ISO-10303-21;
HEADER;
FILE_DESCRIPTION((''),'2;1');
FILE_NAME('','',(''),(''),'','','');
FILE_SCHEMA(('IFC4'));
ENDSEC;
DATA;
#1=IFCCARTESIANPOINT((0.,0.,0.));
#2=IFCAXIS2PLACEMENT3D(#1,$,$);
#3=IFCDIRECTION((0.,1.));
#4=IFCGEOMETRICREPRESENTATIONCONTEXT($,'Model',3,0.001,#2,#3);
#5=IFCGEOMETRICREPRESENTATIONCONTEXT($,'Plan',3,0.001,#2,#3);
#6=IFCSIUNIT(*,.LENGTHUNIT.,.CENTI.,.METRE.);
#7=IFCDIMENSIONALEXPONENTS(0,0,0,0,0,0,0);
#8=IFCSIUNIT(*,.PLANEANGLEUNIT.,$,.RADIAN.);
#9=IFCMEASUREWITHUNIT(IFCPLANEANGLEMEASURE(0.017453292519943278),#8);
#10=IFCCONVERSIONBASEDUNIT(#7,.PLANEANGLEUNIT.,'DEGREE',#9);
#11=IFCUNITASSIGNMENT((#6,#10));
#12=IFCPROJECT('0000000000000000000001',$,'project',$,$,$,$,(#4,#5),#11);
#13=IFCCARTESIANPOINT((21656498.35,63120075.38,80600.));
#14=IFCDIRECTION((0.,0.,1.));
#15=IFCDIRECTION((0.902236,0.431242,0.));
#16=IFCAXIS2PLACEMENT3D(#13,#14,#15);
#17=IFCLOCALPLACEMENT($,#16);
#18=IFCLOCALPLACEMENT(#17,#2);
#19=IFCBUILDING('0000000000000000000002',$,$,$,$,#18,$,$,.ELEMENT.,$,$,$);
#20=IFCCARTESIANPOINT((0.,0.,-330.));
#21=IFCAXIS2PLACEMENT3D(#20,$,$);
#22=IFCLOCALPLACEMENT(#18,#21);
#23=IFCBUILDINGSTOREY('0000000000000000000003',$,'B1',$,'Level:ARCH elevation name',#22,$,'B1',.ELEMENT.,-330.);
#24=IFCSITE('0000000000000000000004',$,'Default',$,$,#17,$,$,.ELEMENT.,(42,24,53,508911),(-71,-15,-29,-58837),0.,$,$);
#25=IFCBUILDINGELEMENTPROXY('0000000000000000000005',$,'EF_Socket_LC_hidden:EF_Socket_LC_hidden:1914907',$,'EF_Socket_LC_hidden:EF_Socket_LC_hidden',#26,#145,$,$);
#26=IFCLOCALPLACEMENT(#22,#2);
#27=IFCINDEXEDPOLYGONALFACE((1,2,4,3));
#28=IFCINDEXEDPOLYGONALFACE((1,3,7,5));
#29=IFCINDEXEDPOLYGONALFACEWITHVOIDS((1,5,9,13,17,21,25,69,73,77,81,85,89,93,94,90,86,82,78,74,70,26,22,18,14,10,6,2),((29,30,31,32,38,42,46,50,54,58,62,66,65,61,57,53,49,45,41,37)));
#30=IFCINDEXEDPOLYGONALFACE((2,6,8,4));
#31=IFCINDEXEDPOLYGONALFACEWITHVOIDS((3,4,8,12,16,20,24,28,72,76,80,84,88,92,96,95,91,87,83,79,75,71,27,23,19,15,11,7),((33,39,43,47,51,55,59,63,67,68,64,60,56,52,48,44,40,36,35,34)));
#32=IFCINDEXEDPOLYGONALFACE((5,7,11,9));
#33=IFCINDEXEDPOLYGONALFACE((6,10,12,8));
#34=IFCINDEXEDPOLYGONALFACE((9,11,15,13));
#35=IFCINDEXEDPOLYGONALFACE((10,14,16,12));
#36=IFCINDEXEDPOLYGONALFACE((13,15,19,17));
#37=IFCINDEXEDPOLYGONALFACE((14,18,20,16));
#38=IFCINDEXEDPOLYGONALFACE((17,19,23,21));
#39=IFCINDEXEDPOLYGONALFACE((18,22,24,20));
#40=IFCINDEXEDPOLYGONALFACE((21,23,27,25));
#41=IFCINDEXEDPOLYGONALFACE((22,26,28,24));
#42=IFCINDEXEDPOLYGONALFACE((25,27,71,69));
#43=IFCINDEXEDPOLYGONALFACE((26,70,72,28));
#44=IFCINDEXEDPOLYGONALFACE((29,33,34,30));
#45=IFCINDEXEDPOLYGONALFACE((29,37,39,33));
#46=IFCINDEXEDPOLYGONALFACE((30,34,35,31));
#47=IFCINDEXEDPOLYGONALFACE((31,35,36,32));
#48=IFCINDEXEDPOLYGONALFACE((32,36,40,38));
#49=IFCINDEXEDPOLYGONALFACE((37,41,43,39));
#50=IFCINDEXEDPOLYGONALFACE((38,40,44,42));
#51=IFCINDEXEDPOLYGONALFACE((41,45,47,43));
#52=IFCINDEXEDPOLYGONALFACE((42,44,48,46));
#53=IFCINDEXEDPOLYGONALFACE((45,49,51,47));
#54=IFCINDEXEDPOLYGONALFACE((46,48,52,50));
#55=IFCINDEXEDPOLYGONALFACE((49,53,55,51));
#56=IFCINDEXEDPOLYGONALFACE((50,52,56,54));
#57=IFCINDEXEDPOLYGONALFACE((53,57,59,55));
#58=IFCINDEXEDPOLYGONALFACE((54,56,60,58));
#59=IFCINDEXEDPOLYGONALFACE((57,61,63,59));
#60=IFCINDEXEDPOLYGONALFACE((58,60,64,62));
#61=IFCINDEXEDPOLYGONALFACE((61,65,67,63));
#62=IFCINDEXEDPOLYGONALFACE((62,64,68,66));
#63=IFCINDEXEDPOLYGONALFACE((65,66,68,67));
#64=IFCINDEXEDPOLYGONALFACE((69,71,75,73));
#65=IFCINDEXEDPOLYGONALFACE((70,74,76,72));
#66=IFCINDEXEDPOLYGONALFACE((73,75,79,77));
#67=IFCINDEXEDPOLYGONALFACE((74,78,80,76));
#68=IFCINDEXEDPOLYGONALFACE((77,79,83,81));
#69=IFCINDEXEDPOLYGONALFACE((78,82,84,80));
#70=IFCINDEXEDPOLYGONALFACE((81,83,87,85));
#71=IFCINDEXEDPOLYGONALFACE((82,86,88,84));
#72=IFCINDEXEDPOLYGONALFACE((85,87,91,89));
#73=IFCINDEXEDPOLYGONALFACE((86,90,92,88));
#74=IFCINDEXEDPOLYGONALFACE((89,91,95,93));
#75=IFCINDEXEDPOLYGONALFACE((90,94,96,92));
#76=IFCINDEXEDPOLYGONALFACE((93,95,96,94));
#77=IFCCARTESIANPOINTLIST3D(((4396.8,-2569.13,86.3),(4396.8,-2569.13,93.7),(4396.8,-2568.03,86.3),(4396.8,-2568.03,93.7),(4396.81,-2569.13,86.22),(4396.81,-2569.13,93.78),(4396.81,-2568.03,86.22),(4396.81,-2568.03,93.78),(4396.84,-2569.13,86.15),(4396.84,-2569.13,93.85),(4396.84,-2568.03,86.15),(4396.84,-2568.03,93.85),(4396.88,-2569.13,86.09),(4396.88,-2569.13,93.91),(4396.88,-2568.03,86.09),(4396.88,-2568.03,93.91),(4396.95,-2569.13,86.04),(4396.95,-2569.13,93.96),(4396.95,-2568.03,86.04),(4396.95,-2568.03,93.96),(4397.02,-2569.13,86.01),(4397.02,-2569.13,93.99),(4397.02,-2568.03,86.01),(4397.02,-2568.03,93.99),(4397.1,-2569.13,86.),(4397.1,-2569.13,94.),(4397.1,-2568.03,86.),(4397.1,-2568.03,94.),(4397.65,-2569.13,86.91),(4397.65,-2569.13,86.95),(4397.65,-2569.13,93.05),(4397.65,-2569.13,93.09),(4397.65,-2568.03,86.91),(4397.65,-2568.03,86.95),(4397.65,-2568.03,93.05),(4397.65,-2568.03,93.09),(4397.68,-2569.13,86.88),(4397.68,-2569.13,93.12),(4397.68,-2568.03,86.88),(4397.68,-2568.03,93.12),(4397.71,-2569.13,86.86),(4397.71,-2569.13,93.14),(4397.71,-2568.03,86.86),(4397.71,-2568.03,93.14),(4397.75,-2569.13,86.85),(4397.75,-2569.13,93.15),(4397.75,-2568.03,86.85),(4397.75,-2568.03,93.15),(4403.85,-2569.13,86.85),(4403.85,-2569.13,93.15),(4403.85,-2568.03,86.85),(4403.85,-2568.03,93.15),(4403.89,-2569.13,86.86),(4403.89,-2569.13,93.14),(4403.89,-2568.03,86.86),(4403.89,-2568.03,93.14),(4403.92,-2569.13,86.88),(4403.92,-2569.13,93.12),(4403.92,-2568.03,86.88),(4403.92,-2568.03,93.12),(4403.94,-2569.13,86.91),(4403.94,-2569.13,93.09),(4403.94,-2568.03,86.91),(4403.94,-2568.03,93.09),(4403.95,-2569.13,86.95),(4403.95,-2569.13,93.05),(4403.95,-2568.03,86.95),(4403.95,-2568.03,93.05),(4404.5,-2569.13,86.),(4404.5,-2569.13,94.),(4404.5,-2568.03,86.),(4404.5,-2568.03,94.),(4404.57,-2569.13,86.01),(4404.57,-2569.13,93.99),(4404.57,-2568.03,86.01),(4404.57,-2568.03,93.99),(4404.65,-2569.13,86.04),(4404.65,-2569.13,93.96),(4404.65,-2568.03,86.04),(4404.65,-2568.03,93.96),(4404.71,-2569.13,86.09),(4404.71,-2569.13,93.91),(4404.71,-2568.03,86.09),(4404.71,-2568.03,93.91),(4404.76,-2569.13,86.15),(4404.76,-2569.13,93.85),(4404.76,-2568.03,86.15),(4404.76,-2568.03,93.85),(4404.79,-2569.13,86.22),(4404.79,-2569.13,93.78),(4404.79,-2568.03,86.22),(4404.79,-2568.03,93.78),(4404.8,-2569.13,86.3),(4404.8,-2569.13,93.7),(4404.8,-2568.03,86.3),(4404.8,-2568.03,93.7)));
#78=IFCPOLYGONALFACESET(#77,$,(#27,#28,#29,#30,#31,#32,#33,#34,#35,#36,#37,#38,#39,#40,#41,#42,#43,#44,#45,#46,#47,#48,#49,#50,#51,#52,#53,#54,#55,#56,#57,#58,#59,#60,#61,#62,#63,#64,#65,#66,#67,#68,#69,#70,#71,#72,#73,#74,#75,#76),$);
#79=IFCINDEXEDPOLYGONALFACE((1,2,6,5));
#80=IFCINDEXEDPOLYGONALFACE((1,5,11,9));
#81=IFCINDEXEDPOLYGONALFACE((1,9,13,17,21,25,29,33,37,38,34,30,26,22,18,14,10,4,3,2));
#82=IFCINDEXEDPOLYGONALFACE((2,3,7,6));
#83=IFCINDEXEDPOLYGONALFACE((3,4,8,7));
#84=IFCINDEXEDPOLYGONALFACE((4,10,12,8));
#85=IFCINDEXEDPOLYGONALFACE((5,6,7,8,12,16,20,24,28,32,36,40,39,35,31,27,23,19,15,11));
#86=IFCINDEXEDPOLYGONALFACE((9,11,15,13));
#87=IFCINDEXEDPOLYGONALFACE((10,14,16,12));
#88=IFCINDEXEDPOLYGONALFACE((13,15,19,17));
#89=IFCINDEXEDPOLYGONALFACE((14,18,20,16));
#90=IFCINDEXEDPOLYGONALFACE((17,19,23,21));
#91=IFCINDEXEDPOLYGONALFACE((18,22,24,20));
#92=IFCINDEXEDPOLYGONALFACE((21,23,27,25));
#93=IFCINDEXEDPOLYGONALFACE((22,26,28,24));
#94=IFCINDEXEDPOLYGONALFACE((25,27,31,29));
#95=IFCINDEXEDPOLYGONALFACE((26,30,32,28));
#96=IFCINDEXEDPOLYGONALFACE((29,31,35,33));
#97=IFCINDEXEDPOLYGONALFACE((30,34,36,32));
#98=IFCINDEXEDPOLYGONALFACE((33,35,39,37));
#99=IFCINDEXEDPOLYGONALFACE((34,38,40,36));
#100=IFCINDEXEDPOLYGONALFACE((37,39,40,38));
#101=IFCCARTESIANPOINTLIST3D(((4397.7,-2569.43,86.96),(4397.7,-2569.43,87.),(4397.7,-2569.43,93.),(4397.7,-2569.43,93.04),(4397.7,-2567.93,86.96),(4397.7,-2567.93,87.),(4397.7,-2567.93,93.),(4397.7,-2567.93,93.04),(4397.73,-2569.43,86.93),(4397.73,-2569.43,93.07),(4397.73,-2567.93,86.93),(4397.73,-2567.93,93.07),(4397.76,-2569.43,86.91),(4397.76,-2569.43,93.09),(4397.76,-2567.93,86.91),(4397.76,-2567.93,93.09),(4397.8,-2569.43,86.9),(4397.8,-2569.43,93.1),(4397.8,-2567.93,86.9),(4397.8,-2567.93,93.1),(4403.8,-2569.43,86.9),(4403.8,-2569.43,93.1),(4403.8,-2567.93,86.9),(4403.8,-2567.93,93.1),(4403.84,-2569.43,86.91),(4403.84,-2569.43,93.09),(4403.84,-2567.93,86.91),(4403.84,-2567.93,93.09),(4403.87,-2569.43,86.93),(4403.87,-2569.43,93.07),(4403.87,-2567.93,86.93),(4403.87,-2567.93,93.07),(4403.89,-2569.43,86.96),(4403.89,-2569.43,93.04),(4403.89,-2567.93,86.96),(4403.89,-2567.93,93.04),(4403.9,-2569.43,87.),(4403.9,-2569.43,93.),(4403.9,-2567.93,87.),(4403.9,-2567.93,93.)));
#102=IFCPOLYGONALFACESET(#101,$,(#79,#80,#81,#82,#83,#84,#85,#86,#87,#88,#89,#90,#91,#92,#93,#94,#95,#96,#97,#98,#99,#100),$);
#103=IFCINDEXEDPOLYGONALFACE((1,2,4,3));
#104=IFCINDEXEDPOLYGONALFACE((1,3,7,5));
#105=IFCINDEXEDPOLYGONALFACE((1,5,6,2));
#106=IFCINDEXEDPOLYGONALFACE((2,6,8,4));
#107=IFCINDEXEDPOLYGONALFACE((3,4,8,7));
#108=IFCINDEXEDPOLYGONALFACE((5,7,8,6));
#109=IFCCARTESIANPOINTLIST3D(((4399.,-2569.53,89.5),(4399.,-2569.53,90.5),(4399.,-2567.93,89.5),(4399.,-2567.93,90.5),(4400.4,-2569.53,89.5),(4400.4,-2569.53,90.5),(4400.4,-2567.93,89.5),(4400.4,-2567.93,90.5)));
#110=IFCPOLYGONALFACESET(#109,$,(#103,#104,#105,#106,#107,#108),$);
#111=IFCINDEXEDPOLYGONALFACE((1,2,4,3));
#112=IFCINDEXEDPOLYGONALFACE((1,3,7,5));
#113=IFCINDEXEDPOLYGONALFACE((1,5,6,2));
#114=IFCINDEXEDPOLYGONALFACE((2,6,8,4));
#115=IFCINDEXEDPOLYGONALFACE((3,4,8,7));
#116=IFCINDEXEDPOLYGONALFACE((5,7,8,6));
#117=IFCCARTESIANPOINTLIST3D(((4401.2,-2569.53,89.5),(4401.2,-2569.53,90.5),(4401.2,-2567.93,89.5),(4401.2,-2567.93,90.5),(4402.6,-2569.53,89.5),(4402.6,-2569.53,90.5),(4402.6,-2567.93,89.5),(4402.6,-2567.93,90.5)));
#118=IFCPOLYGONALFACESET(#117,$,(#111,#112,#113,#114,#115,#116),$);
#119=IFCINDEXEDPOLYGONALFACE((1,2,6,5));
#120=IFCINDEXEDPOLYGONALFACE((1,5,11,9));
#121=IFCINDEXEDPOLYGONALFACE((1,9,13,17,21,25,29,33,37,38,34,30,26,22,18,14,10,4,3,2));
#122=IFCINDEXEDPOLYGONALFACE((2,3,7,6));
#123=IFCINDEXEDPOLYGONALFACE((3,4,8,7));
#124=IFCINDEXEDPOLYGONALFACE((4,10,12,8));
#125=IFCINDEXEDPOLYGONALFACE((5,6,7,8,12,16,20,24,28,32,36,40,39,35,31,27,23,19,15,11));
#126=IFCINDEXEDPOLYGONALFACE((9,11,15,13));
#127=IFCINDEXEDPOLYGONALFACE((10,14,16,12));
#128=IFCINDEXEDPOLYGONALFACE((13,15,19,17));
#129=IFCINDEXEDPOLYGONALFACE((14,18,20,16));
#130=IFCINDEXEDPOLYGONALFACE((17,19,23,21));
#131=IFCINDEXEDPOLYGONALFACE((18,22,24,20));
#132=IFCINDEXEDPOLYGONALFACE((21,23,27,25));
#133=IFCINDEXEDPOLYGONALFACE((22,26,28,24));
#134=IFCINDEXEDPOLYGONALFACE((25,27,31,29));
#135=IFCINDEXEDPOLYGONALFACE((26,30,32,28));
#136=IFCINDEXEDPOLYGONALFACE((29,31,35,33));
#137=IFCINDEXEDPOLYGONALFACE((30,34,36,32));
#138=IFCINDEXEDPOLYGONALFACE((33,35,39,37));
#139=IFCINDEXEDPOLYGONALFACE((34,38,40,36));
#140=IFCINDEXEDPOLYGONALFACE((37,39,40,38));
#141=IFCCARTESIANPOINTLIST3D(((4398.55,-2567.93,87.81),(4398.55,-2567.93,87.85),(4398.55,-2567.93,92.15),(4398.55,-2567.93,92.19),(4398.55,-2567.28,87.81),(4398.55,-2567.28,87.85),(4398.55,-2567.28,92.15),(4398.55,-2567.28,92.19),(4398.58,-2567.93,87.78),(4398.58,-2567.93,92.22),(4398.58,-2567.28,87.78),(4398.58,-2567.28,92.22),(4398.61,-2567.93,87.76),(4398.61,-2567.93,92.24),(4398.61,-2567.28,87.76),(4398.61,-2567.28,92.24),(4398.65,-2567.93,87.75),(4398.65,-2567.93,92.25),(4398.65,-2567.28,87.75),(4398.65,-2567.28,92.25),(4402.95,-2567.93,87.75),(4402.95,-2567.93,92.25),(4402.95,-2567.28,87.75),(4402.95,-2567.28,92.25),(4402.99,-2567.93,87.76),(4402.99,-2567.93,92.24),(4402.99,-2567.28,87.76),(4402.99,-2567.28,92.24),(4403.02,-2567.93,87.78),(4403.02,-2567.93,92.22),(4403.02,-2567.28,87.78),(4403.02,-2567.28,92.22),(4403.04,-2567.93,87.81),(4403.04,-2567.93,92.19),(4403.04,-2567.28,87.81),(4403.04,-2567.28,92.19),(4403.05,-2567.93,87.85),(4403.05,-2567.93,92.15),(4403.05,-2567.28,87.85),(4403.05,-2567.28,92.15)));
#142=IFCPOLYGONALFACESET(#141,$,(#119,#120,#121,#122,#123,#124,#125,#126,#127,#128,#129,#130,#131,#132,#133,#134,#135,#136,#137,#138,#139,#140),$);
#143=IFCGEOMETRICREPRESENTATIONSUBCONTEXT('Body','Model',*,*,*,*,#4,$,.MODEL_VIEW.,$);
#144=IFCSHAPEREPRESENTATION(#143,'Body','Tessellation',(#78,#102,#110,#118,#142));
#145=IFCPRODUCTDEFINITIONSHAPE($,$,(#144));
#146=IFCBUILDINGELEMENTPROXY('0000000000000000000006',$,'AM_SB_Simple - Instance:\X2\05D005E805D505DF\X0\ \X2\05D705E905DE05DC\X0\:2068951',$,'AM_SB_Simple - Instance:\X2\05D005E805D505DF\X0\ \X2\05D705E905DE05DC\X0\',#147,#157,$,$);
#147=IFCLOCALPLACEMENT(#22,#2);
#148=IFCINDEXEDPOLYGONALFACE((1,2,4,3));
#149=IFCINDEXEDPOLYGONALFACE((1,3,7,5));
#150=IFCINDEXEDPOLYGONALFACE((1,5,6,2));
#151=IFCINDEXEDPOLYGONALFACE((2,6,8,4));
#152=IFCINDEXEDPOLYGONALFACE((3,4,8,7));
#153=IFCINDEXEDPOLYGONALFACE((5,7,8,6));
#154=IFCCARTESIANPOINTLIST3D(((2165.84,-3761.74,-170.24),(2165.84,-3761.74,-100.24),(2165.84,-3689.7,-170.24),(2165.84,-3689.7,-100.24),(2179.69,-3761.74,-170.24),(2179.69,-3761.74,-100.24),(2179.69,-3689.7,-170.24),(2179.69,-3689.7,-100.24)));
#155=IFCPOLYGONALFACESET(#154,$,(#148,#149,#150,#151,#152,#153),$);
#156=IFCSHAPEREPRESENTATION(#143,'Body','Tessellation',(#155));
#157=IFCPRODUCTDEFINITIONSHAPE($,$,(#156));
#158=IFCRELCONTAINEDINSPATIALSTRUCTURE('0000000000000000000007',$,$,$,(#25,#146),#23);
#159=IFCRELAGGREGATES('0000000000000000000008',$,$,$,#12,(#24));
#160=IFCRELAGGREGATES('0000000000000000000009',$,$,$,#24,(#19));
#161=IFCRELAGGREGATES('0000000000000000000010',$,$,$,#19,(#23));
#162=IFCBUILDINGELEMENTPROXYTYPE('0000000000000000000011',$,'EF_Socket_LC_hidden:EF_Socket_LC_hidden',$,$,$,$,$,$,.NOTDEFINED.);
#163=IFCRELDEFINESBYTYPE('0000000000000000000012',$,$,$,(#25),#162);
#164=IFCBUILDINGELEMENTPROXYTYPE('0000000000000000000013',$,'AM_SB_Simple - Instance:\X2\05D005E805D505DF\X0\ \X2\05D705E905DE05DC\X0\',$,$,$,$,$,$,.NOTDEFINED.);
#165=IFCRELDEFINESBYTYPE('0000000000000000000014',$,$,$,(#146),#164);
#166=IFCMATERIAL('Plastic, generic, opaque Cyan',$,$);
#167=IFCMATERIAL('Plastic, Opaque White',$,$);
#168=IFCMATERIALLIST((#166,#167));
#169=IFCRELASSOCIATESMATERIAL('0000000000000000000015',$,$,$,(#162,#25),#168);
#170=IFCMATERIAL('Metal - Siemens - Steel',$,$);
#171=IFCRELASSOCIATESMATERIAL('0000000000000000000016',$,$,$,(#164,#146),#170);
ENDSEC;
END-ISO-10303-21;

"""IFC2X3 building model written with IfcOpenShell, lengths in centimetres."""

from ifc_helpers import new_model, entity, si_unit, converted_unit, direction, frame, frame_2d, origin, origin_2d_with_axis, place, context, subcontext, project, spatial, polyline, circle_curve, parameter, trimmed, segment, composite_curve, rectangle, outline, extrude, source, transform, mapped, material, material_list, type_object, type_shapes, element, save


model = new_model("IFC2X3")

# Units and contexts
model_context = context("Model", 3, precision=0.001, world=origin(), true_north=direction((0.0, 1.0)))
plan_context = context("Plan", 3, precision=0.001, world=origin(), true_north=direction((0.0, 1.0)))
body_context = subcontext(model_context, "Body", "Model", "MODEL_VIEW")
ifc_project = project(units=[si_unit("LENGTHUNIT", "METRE", prefix="CENTI"), converted_unit("PLANEANGLEUNIT", "DEGREE", entity("IfcPlaneAngleMeasure", 0.017453292519943278), si_unit("PLANEANGLEUNIT", "RADIAN"), dimensions=[0, 0, 0, 0, 0, 0, 0])], contexts=[model_context, plan_context])

# Site, building, storey
site_placement = place(None, frame((21656498.35, 63120075.38, 80600.0), z_axis=(0.0, 0.0, 1.0), x_axis=(0.902236, 0.431242, 0.0)))
site = spatial("IfcSite", under=ifc_project, at=site_placement, Name="Default", CompositionType="ELEMENT", RefLatitude=(42, 24, 53, 508911), RefLongitude=(-71, -15, -29, -58837), RefElevation=0.0)
building_placement = place(site_placement, origin())
building = spatial("IfcBuilding", under=site, at=building_placement, CompositionType="ELEMENT")
storey_placement = place(building_placement, frame((0.0, 0.0, -330.0)))
storey = spatial("IfcBuildingStorey", under=building, at=storey_placement, Name="B1", ObjectType="Level:ARCH elevation name", LongName="B1", CompositionType="ELEMENT", Elevation=-330.0)

# Building element proxies
ifc_material_1 = material(Name="Plastic, generic, opaque Cyan")
ifc_material_2 = material(Name="Plastic, Opaque White")
ifc_material_list_1 = material_list([ifc_material_1, ifc_material_2])
building_element_proxy_type_1 = type_object("IfcBuildingElementProxyType", Name="EF_Socket_LC_hidden:EF_Socket_LC_hidden", PredefinedType="NOTDEFINED", material=ifc_material_list_1)
shared_shape_1 = source(origin(), body_context, "Body", "SweptSolid", [
    extrude(outline(composite_curve([segment(trimmed(circle_curve(frame_2d((3.7, -3.7), x_axis=(1.0, 0.0)), 0.3), [parameter(270.0)], [parameter(0.0)], True, "PARAMETER"), True, "CONTINUOUS"), segment(polyline([(4.0, -3.7), (4.0, 3.7)]), True, "CONTINUOUS"), segment(trimmed(circle_curve(frame_2d((3.7, 3.7), x_axis=(1.0, 0.0)), 0.3), [parameter(0.0)], [parameter(90.0)], True, "PARAMETER"), True, "CONTINUOUS"), segment(polyline([(3.7, 4.0), (-3.7, 4.0)]), True, "CONTINUOUS"), segment(trimmed(circle_curve(frame_2d((-3.7, 3.7), x_axis=(1.0, 0.0)), 0.3), [parameter(90.0)], [parameter(180.0)], True, "PARAMETER"), True, "CONTINUOUS"), segment(polyline([(-4.0, 3.7), (-4.0, -3.7)]), True, "CONTINUOUS"), segment(trimmed(circle_curve(frame_2d((-3.7, -3.7), x_axis=(1.0, 0.0)), 0.3), [parameter(180.0)], [parameter(270.0)], True, "PARAMETER"), True, "CONTINUOUS"), segment(polyline([(-3.7, -4.0), (3.7, -4.0)]), True, "CONTINUOUS")], self_intersect=False), holes=[composite_curve([segment(polyline([(-3.15, -3.05), (-3.15, 3.05)]), True, "CONTINUOUS"), segment(trimmed(circle_curve(frame_2d((-3.05, 3.05), x_axis=(1.0, 0.0)), 0.1), [parameter(90.0)], [parameter(180.0)], True, "PARAMETER"), False, "CONTINUOUS"), segment(polyline([(-3.05, 3.15), (3.05, 3.15)]), True, "CONTINUOUS"), segment(trimmed(circle_curve(frame_2d((3.05, 3.05), x_axis=(1.0, 0.0)), 0.1), [parameter(360.0)], [parameter(90.0)], True, "PARAMETER"), False, "CONTINUOUS"), segment(polyline([(3.15, 3.05), (3.15, -3.05)]), True, "CONTINUOUS"), segment(trimmed(circle_curve(frame_2d((3.05, -3.05), x_axis=(1.0, 0.0)), 0.1), [parameter(270.0)], [parameter(360.0)], True, "PARAMETER"), False, "CONTINUOUS"), segment(polyline([(3.05, -3.15), (-3.05, -3.15)]), True, "CONTINUOUS"), segment(trimmed(circle_curve(frame_2d((-3.05, -3.05), x_axis=(1.0, 0.0)), 0.1), [parameter(180.0)], [parameter(270.0)], True, "PARAMETER"), False, "CONTINUOUS")], self_intersect=False)]), frame((0.0, 0.0, 0.0), z_axis=(0.0, 1.0, 0.0), x_axis=(1.0, 0.0, 0.0)), (0.0, 0.0, 1.0), 1.1),
    extrude(outline(composite_curve([segment(trimmed(circle_curve(frame_2d((3.0, -3.0), x_axis=(1.0, 0.0)), 0.1), [parameter(270.0)], [parameter(0.0)], True, "PARAMETER"), True, "CONTINUOUS"), segment(polyline([(3.1, -3.0), (3.1, 3.0)]), True, "CONTINUOUS"), segment(trimmed(circle_curve(frame_2d((3.0, 3.0), x_axis=(1.0, 0.0)), 0.1), [parameter(0.0)], [parameter(90.0)], True, "PARAMETER"), True, "CONTINUOUS"), segment(polyline([(3.0, 3.1), (-3.0, 3.1)]), True, "CONTINUOUS"), segment(trimmed(circle_curve(frame_2d((-3.0, 3.0), x_axis=(1.0, 0.0)), 0.1), [parameter(90.0)], [parameter(180.0)], True, "PARAMETER"), True, "CONTINUOUS"), segment(polyline([(-3.1, 3.0), (-3.1, -3.0)]), True, "CONTINUOUS"), segment(trimmed(circle_curve(frame_2d((-3.0, -3.0), x_axis=(1.0, 0.0)), 0.1), [parameter(180.0)], [parameter(270.0)], True, "PARAMETER"), True, "CONTINUOUS"), segment(polyline([(-3.0, -3.1), (3.0, -3.1)]), True, "CONTINUOUS")], self_intersect=False)), frame((0.0, -0.1, 0.0), z_axis=(0.0, 1.0, 0.0), x_axis=(1.0, 0.0, 0.0)), (0.0, 0.0, 1.0), 1.5),
    extrude(rectangle(XDim=1.6, YDim=1.4, at=frame_2d((0.0, 0.0), x_axis=(1.0, 0.0))), frame((1.1, 0.7, -0.5), z_axis=(0.0, 0.0, 1.0), x_axis=(0.0, -1.0, 0.0)), (0.0, 0.0, 1.0), 1.0),
    extrude(rectangle(XDim=1.6, YDim=1.4, at=frame_2d((0.0, 0.0), x_axis=(1.0, 0.0))), frame((-1.1, 0.7, -0.5), z_axis=(0.0, 0.0, 1.0), x_axis=(0.0, -1.0, 0.0)), (0.0, 0.0, 1.0), 1.0),
    extrude(outline(composite_curve([segment(trimmed(circle_curve(frame_2d((2.15, -2.15), x_axis=(1.0, 0.0)), 0.1), [parameter(270.0)], [parameter(0.0)], True, "PARAMETER"), True, "CONTINUOUS"), segment(polyline([(2.25, -2.15), (2.25, 2.15)]), True, "CONTINUOUS"), segment(trimmed(circle_curve(frame_2d((2.15, 2.15), x_axis=(1.0, 0.0)), 0.1), [parameter(0.0)], [parameter(90.0)], True, "PARAMETER"), True, "CONTINUOUS"), segment(polyline([(2.15, 2.25), (-2.15, 2.25)]), True, "CONTINUOUS"), segment(trimmed(circle_curve(frame_2d((-2.15, 2.15), x_axis=(1.0, 0.0)), 0.1), [parameter(90.0)], [parameter(180.0)], True, "PARAMETER"), True, "CONTINUOUS"), segment(polyline([(-2.25, 2.15), (-2.25, -2.15)]), True, "CONTINUOUS"), segment(trimmed(circle_curve(frame_2d((-2.15, -2.15), x_axis=(1.0, 0.0)), 0.1), [parameter(180.0)], [parameter(270.0)], True, "PARAMETER"), True, "CONTINUOUS"), segment(polyline([(-2.15, -2.25), (2.15, -2.25)]), True, "CONTINUOUS")], self_intersect=False)), frame((0.0, -0.75, 0.0), z_axis=(0.0, 1.0, 0.0), x_axis=(1.0, 0.0, 0.0)), (0.0, 0.0, 1.0), 0.65),
])
type_shapes(building_element_proxy_type_1, [shared_shape_1])
proxy_1_placement = place(storey_placement, frame((4400.8, -2568.03, 90.0), z_axis=(0.0, 0.0, 1.0), x_axis=(-1.0, 0.0, 0.0)))
element("IfcBuildingElementProxy", 1, at=proxy_1_placement, inside=storey, type_object=building_element_proxy_type_1, material=ifc_material_list_1, Name="EF_Socket_LC_hidden:EF_Socket_LC_hidden:1914907", ObjectType="EF_Socket_LC_hidden:EF_Socket_LC_hidden", context=body_context, shape_type="MappedRepresentation", body=[
    mapped(shared_shape_1, transform((0.0, 0.0, 0.0), scale=1.0)),
])
ifc_material_3 = material(Name="Metal - Siemens - Steel")
building_element_proxy_type_2 = type_object("IfcBuildingElementProxyType", Name="AM_SB_Simple - Instance:ארון חשמל", PredefinedType="NOTDEFINED", material=ifc_material_3)
shared_shape_2 = source(origin(), body_context, "Body", "SweptSolid", [
    extrude(rectangle(XDim=72.04, YDim=13.85, at=origin_2d_with_axis()), frame((0.0, 0.0, 0.0), z_axis=(0.0, 0.0, 1.0), x_axis=(-1.0, 0.0, 0.0)), (0.0, 0.0, 1.0), 70.0),
])
type_shapes(building_element_proxy_type_2, [shared_shape_2])
for number, where, z_axis, x_axis, name in (
    (2, (2172.77, -3725.72, -170.24), (0.0, 0.0, 1.0), (0.0, 1.0, 0.0), "AM_SB_Simple - Instance:ארון חשמל:2068951"),
):
    element("IfcBuildingElementProxy", number, at=place(storey_placement, frame(where, z_axis=z_axis, x_axis=x_axis)), inside=storey, type_object=building_element_proxy_type_2, material=ifc_material_3, Name=name, ObjectType="AM_SB_Simple - Instance:ארון חשמל", context=body_context, shape_type="MappedRepresentation", body=[
        mapped(shared_shape_2, transform((0.0, 0.0, 0.0), scale=1.0)),
    ])

save(model, "model.ifc")
